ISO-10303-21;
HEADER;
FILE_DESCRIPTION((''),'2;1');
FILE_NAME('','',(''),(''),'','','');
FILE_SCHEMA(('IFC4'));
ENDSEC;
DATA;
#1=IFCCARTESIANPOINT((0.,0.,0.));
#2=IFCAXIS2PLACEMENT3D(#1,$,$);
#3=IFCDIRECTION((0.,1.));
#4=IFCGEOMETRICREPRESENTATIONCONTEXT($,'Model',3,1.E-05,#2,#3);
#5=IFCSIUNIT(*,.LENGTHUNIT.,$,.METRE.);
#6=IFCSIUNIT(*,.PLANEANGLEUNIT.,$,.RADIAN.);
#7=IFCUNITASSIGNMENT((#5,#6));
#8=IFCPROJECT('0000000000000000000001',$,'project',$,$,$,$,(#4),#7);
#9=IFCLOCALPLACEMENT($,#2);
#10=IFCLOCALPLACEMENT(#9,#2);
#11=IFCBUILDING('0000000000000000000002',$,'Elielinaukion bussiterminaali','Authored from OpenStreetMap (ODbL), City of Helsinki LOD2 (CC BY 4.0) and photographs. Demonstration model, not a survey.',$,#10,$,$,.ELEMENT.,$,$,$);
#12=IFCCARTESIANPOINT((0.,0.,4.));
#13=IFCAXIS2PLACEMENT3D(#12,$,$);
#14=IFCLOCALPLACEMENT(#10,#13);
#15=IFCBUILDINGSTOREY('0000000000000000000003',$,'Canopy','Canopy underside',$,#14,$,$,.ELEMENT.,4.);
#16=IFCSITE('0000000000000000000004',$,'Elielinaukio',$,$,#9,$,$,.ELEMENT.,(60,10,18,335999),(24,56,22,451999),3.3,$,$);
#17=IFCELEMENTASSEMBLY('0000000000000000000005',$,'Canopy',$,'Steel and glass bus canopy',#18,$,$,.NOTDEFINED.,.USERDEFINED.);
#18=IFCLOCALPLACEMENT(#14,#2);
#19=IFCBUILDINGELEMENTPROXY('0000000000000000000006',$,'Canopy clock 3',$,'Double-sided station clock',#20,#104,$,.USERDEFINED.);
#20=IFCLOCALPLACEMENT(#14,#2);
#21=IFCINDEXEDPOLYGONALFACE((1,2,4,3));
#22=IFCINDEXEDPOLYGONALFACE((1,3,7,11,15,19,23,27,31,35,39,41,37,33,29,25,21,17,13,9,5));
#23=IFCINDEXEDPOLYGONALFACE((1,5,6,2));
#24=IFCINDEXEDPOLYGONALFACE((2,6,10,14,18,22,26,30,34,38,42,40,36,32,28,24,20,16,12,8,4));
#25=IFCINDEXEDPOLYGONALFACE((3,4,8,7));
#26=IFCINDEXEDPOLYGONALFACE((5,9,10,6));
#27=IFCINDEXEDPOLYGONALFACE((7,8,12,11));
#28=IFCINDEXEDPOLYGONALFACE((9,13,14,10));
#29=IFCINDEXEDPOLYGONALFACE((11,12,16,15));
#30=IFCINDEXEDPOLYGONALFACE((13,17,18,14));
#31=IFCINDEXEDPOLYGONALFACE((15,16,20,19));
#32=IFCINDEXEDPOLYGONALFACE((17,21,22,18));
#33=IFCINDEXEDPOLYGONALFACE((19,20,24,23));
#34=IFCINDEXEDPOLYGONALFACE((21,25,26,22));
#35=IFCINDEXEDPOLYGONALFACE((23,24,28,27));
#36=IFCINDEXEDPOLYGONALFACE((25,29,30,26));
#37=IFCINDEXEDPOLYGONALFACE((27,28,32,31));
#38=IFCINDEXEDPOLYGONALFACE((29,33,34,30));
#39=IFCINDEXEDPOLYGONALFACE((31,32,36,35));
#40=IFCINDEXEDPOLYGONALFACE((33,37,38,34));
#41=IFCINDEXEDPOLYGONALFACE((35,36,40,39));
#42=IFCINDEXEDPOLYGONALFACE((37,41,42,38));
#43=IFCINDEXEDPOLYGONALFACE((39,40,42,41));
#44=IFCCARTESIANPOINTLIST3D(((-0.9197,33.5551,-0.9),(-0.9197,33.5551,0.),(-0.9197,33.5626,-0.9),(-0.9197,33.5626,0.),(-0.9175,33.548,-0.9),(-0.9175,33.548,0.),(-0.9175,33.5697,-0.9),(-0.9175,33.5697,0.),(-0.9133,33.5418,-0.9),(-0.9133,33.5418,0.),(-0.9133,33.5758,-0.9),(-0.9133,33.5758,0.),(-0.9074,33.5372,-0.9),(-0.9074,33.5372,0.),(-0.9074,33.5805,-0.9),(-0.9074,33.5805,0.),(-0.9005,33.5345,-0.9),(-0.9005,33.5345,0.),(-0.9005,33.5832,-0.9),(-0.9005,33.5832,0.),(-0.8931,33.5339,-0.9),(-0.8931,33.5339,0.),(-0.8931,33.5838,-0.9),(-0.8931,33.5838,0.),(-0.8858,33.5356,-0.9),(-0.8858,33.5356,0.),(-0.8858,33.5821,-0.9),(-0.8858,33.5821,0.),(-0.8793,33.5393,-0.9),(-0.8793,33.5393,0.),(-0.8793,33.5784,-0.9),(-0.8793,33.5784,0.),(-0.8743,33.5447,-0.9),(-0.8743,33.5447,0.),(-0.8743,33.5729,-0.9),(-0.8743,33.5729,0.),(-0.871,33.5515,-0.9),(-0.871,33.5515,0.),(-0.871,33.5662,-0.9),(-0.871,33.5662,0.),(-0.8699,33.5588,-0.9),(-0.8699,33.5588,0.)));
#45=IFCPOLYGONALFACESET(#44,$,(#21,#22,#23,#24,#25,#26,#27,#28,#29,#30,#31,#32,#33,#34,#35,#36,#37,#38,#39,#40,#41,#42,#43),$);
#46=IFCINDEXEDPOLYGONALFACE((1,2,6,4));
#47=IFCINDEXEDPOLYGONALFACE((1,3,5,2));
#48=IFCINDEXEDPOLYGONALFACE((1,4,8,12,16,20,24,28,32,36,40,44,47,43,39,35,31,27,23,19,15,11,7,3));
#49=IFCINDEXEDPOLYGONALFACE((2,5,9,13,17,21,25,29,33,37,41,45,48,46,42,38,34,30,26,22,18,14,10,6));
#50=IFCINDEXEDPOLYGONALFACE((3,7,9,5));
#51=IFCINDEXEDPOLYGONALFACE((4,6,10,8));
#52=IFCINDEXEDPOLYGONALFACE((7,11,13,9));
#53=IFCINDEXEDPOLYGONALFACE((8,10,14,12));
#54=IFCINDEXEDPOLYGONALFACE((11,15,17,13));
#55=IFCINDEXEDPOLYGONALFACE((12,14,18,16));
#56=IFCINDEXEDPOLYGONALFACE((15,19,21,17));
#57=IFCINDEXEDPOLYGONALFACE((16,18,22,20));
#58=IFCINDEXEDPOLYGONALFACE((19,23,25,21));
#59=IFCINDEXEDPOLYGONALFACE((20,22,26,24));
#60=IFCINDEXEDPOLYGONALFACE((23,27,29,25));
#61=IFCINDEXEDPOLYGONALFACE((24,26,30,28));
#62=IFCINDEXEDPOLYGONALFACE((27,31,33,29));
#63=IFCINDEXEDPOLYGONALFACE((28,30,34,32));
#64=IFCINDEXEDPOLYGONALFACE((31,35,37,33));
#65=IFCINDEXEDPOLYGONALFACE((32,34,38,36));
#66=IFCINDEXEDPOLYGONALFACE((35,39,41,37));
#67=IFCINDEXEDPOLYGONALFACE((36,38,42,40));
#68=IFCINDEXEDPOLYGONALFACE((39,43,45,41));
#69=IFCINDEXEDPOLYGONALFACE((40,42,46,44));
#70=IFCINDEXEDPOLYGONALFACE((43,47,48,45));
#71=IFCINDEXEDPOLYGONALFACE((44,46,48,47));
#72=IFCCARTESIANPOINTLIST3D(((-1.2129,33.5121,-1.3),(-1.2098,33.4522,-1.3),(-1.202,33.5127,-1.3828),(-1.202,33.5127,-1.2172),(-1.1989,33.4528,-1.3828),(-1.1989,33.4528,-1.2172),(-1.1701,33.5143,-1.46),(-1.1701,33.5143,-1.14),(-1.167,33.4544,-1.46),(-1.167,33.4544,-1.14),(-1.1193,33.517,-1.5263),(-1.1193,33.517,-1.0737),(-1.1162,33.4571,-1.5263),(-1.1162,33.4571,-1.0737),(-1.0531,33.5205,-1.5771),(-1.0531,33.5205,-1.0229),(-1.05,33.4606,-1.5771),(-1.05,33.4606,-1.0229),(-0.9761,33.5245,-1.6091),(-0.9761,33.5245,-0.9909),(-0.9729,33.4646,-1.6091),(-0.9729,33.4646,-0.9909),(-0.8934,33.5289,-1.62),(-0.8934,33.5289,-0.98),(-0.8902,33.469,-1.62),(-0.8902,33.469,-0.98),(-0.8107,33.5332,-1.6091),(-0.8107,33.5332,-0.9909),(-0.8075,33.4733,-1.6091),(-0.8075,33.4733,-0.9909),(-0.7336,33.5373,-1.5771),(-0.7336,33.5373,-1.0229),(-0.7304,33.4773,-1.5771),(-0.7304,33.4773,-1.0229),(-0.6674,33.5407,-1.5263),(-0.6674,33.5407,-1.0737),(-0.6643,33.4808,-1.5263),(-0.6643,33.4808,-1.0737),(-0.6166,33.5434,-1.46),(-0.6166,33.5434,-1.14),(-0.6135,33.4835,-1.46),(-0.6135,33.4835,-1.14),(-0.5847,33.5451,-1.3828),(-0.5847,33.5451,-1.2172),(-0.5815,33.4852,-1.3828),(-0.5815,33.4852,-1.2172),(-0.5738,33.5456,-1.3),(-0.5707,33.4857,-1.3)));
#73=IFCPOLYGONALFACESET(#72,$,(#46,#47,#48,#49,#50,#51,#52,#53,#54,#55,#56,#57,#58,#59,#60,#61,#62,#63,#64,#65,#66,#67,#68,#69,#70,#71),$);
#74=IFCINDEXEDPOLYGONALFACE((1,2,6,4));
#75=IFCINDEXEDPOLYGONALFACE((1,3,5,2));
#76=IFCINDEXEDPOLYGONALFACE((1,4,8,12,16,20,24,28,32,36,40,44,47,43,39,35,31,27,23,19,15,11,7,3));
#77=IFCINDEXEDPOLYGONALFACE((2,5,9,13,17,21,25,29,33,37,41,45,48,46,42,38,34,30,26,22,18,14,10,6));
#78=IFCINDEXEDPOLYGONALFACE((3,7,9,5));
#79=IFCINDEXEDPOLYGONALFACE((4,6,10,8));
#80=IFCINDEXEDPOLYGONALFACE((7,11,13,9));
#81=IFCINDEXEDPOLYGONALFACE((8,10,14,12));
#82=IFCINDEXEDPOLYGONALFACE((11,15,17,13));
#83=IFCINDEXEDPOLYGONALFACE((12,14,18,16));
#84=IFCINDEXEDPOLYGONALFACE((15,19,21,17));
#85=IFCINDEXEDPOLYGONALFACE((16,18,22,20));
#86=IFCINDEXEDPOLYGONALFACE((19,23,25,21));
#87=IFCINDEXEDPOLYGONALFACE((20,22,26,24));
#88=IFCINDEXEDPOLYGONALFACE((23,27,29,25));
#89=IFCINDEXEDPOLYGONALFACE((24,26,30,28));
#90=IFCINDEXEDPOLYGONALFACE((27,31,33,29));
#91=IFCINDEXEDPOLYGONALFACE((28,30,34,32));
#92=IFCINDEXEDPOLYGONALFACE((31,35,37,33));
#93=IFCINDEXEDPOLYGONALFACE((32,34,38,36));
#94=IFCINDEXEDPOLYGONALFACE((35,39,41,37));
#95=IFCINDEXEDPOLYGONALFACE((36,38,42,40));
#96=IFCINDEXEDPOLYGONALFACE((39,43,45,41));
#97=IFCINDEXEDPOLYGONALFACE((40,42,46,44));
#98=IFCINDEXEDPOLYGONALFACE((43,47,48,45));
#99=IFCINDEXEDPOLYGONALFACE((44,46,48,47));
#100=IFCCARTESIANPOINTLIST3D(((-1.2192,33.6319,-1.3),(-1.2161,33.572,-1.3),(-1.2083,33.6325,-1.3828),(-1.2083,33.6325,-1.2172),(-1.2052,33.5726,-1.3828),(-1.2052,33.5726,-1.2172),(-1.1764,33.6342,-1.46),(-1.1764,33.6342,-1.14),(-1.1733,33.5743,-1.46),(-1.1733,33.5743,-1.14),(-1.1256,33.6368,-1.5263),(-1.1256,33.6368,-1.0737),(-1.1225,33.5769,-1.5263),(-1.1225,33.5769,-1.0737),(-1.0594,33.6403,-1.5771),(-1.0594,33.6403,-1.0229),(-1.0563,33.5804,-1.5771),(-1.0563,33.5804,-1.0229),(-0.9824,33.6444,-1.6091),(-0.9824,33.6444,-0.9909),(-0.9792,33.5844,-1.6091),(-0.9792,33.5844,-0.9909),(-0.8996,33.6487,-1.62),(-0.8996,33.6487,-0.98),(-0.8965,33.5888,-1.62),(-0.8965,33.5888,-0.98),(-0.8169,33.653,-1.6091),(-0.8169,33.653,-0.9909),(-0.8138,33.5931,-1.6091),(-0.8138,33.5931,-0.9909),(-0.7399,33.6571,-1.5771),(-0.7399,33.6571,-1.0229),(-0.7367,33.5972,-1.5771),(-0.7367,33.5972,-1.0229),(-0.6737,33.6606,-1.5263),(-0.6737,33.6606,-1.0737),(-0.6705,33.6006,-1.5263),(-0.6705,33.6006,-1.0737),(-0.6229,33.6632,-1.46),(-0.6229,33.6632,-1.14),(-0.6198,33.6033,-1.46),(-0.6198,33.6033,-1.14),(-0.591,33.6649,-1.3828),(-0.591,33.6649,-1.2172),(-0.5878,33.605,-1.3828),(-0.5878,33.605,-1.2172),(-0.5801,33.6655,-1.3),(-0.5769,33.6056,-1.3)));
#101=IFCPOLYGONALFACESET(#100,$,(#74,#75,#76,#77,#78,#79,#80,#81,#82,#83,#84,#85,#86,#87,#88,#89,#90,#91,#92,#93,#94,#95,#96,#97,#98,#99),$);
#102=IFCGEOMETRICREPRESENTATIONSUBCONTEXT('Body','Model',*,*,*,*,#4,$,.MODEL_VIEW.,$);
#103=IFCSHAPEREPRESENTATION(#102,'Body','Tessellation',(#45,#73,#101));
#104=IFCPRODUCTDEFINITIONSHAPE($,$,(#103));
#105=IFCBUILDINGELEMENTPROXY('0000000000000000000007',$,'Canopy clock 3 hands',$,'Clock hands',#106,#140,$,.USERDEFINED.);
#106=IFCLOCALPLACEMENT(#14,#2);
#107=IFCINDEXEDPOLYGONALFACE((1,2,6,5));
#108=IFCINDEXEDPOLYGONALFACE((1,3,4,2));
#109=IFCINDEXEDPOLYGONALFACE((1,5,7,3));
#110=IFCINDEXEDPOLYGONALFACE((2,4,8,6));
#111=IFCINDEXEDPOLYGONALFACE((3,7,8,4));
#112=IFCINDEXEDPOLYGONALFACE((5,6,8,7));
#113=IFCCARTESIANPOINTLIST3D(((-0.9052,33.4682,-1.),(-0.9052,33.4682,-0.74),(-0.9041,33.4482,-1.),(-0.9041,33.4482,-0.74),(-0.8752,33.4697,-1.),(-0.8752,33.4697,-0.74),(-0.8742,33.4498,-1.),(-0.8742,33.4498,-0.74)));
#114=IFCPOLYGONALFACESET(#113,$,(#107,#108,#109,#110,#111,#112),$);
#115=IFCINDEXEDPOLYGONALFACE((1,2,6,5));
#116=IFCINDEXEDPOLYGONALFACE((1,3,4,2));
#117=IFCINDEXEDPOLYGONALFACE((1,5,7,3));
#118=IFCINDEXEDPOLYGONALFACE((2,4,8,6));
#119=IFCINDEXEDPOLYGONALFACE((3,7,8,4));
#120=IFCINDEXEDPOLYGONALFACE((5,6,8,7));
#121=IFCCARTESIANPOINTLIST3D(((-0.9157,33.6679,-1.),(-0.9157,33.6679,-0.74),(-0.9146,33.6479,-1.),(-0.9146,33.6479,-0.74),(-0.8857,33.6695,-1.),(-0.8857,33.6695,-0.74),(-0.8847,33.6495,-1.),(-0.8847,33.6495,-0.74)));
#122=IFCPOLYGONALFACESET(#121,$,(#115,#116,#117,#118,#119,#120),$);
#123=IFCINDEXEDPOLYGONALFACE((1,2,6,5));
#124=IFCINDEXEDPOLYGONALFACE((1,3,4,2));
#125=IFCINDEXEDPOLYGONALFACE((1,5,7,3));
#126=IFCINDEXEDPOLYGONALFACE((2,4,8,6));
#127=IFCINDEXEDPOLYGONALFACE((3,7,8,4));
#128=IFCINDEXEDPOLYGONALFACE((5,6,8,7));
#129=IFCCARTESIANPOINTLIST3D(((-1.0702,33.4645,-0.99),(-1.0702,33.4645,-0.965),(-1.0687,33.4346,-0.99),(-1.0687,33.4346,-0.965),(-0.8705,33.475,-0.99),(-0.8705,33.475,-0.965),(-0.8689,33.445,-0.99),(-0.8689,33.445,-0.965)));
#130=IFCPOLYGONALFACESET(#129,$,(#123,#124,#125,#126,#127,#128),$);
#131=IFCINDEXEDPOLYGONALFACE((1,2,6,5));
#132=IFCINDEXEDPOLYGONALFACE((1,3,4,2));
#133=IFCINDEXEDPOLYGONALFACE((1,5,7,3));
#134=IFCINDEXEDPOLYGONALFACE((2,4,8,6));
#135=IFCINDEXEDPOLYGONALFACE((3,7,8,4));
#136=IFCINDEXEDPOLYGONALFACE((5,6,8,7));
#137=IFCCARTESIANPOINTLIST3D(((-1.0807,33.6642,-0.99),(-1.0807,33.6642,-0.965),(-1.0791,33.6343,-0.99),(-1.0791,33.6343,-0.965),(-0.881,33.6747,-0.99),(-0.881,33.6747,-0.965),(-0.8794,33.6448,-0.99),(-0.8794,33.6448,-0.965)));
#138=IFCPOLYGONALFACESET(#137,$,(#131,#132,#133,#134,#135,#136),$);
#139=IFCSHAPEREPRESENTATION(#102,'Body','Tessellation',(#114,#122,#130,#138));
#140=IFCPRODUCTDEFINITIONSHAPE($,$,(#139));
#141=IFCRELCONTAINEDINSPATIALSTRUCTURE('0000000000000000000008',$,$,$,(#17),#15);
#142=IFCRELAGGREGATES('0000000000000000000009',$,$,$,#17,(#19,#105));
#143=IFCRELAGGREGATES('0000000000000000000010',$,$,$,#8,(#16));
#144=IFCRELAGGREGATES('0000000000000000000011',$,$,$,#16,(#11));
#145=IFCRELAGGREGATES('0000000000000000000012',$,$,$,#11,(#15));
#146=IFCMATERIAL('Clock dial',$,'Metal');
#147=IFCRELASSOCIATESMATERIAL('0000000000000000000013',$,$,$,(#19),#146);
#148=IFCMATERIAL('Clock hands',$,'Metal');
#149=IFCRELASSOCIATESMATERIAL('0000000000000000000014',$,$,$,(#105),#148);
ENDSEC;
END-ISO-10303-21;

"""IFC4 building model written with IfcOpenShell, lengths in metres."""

from ifc_helpers import new_model, si_unit, direction, frame, frame_2d, origin, origin_2d_with_axis, place, context, subcontext, project, spatial, polyline, rectangle, circle, outline, extrude, material, element, aggregate, save


model = new_model("IFC4")

# Units and contexts
model_context = context("Model", 3, precision=1e-05, world=origin(), true_north=direction((0.0, 1.0)))
body_context = subcontext(model_context, "Body", "Model", "MODEL_VIEW")
ifc_project = project(units=[si_unit("LENGTHUNIT", "METRE"), si_unit("PLANEANGLEUNIT", "RADIAN")], contexts=[model_context])

# Site, building, storey
site_placement = place(None, origin())
site = spatial("IfcSite", under=ifc_project, at=site_placement, Name="Elielinaukio", CompositionType="ELEMENT", RefLatitude=(60, 10, 18, 335999), RefLongitude=(24, 56, 22, 451999), RefElevation=3.3)
building_placement = place(site_placement, origin())
building = spatial("IfcBuilding", under=site, at=building_placement, Name="Elielinaukion bussiterminaali", Description="Authored from OpenStreetMap (ODbL), City of Helsinki LOD2 (CC BY 4.0) and photographs. Demonstration model, not a survey.", CompositionType="ELEMENT")
storey_placement = place(building_placement, frame((0.0, 0.0, 4.0)))
storey = spatial("IfcBuildingStorey", under=building, at=storey_placement, Name="Canopy", Description="Canopy underside", CompositionType="ELEMENT", Elevation=4.0)

# Element assembly, building element proxies
assembly_placement = place(building_placement, origin())
assembly = element("IfcElementAssembly", 1, at=assembly_placement, inside=storey, Name="Canopy", ObjectType="Steel and glass bus canopy", AssemblyPlace="NOTDEFINED", PredefinedType="USERDEFINED")
ifc_material_1 = material(Name="Clock dial", Category="Metal")
ifc_material_2 = material(Name="Clock hands", Category="Metal")
proxy_1_placement = place(building_placement, origin())
proxy_1 = element("IfcBuildingElementProxy", 2, at=proxy_1_placement, material=ifc_material_1, Name="Canopy clock 3", ObjectType="Double-sided station clock", PredefinedType="USERDEFINED", context=body_context, shape_type="SweptSolid", body=[
    extrude(circle(Radius=0.025, at=origin_2d_with_axis()), frame((-0.8949, 33.5588, 3.1)), (0.0, 0.0, 1.0), 0.9),
    extrude(outline(polyline([(0.32, 0.0), (0.3091, 0.0828), (0.2771, 0.16), (0.2263, 0.2263), (0.16, 0.2771), (0.0828, 0.3091), (0.0, 0.32), (-0.0828, 0.3091), (-0.16, 0.2771), (-0.2263, 0.2263), (-0.2771, 0.16), (-0.3091, 0.0828), (-0.32, 0.0), (-0.3091, -0.0828), (-0.2771, -0.16), (-0.2263, -0.2263), (-0.16, -0.2771), (-0.0828, -0.3091), (0.0, -0.32), (0.0828, -0.3091), (0.16, -0.2771), (0.2263, -0.2263), (0.2771, -0.16), (0.3091, -0.0828), (0.32, 0.0)])), frame((-0.8902, 33.469, 2.7), z_axis=(-0.052408, 0.998626, 0.0), x_axis=(-0.998626, -0.052408, 0.0)), (0.0, 0.0, 1.0), 0.06),
    extrude(outline(polyline([(0.32, 0.0), (0.3091, 0.0828), (0.2771, 0.16), (0.2263, 0.2263), (0.16, 0.2771), (0.0828, 0.3091), (0.0, 0.32), (-0.0828, 0.3091), (-0.16, 0.2771), (-0.2263, 0.2263), (-0.2771, 0.16), (-0.3091, 0.0828), (-0.32, 0.0), (-0.3091, -0.0828), (-0.2771, -0.16), (-0.2263, -0.2263), (-0.16, -0.2771), (-0.0828, -0.3091), (0.0, -0.32), (0.0828, -0.3091), (0.16, -0.2771), (0.2263, -0.2263), (0.2771, -0.16), (0.3091, -0.0828), (0.32, 0.0)])), frame((-0.8965, 33.5888, 2.7), z_axis=(-0.052408, 0.998626, 0.0), x_axis=(-0.998626, -0.052408, 0.0)), (0.0, 0.0, 1.0), 0.06),
])
proxy_2_placement = place(building_placement, origin())
proxy_2 = element("IfcBuildingElementProxy", 3, at=proxy_2_placement, material=ifc_material_2, Name="Canopy clock 3 hands", ObjectType="Clock hands", PredefinedType="USERDEFINED", context=body_context, shape_type="SweptSolid", body=[
    extrude(rectangle(XDim=0.03, YDim=0.02, at=frame_2d((0.0, 0.0), x_axis=(-0.998626, -0.052408))), frame((-0.8897, 33.459, 3.0)), (0.0, 0.0, 1.0), 0.26),
    extrude(rectangle(XDim=0.03, YDim=0.02, at=frame_2d((0.0, 0.0), x_axis=(-0.998626, -0.052408))), frame((-0.9002, 33.6587, 3.0)), (0.0, 0.0, 1.0), 0.26),
    extrude(rectangle(XDim=0.03, YDim=0.2, at=frame_2d((0.0, 0.0), x_axis=(-0.052408, 0.998626))), frame((-0.9696, 33.4548, 3.01)), (0.0, 0.0, 1.0), 0.025),
    extrude(rectangle(XDim=0.03, YDim=0.2, at=frame_2d((0.0, 0.0), x_axis=(-0.052408, 0.998626))), frame((-0.9801, 33.6545, 3.01)), (0.0, 0.0, 1.0), 0.025),
])
aggregate(assembly, [proxy_1, proxy_2])

save(model, "model.ifc")
